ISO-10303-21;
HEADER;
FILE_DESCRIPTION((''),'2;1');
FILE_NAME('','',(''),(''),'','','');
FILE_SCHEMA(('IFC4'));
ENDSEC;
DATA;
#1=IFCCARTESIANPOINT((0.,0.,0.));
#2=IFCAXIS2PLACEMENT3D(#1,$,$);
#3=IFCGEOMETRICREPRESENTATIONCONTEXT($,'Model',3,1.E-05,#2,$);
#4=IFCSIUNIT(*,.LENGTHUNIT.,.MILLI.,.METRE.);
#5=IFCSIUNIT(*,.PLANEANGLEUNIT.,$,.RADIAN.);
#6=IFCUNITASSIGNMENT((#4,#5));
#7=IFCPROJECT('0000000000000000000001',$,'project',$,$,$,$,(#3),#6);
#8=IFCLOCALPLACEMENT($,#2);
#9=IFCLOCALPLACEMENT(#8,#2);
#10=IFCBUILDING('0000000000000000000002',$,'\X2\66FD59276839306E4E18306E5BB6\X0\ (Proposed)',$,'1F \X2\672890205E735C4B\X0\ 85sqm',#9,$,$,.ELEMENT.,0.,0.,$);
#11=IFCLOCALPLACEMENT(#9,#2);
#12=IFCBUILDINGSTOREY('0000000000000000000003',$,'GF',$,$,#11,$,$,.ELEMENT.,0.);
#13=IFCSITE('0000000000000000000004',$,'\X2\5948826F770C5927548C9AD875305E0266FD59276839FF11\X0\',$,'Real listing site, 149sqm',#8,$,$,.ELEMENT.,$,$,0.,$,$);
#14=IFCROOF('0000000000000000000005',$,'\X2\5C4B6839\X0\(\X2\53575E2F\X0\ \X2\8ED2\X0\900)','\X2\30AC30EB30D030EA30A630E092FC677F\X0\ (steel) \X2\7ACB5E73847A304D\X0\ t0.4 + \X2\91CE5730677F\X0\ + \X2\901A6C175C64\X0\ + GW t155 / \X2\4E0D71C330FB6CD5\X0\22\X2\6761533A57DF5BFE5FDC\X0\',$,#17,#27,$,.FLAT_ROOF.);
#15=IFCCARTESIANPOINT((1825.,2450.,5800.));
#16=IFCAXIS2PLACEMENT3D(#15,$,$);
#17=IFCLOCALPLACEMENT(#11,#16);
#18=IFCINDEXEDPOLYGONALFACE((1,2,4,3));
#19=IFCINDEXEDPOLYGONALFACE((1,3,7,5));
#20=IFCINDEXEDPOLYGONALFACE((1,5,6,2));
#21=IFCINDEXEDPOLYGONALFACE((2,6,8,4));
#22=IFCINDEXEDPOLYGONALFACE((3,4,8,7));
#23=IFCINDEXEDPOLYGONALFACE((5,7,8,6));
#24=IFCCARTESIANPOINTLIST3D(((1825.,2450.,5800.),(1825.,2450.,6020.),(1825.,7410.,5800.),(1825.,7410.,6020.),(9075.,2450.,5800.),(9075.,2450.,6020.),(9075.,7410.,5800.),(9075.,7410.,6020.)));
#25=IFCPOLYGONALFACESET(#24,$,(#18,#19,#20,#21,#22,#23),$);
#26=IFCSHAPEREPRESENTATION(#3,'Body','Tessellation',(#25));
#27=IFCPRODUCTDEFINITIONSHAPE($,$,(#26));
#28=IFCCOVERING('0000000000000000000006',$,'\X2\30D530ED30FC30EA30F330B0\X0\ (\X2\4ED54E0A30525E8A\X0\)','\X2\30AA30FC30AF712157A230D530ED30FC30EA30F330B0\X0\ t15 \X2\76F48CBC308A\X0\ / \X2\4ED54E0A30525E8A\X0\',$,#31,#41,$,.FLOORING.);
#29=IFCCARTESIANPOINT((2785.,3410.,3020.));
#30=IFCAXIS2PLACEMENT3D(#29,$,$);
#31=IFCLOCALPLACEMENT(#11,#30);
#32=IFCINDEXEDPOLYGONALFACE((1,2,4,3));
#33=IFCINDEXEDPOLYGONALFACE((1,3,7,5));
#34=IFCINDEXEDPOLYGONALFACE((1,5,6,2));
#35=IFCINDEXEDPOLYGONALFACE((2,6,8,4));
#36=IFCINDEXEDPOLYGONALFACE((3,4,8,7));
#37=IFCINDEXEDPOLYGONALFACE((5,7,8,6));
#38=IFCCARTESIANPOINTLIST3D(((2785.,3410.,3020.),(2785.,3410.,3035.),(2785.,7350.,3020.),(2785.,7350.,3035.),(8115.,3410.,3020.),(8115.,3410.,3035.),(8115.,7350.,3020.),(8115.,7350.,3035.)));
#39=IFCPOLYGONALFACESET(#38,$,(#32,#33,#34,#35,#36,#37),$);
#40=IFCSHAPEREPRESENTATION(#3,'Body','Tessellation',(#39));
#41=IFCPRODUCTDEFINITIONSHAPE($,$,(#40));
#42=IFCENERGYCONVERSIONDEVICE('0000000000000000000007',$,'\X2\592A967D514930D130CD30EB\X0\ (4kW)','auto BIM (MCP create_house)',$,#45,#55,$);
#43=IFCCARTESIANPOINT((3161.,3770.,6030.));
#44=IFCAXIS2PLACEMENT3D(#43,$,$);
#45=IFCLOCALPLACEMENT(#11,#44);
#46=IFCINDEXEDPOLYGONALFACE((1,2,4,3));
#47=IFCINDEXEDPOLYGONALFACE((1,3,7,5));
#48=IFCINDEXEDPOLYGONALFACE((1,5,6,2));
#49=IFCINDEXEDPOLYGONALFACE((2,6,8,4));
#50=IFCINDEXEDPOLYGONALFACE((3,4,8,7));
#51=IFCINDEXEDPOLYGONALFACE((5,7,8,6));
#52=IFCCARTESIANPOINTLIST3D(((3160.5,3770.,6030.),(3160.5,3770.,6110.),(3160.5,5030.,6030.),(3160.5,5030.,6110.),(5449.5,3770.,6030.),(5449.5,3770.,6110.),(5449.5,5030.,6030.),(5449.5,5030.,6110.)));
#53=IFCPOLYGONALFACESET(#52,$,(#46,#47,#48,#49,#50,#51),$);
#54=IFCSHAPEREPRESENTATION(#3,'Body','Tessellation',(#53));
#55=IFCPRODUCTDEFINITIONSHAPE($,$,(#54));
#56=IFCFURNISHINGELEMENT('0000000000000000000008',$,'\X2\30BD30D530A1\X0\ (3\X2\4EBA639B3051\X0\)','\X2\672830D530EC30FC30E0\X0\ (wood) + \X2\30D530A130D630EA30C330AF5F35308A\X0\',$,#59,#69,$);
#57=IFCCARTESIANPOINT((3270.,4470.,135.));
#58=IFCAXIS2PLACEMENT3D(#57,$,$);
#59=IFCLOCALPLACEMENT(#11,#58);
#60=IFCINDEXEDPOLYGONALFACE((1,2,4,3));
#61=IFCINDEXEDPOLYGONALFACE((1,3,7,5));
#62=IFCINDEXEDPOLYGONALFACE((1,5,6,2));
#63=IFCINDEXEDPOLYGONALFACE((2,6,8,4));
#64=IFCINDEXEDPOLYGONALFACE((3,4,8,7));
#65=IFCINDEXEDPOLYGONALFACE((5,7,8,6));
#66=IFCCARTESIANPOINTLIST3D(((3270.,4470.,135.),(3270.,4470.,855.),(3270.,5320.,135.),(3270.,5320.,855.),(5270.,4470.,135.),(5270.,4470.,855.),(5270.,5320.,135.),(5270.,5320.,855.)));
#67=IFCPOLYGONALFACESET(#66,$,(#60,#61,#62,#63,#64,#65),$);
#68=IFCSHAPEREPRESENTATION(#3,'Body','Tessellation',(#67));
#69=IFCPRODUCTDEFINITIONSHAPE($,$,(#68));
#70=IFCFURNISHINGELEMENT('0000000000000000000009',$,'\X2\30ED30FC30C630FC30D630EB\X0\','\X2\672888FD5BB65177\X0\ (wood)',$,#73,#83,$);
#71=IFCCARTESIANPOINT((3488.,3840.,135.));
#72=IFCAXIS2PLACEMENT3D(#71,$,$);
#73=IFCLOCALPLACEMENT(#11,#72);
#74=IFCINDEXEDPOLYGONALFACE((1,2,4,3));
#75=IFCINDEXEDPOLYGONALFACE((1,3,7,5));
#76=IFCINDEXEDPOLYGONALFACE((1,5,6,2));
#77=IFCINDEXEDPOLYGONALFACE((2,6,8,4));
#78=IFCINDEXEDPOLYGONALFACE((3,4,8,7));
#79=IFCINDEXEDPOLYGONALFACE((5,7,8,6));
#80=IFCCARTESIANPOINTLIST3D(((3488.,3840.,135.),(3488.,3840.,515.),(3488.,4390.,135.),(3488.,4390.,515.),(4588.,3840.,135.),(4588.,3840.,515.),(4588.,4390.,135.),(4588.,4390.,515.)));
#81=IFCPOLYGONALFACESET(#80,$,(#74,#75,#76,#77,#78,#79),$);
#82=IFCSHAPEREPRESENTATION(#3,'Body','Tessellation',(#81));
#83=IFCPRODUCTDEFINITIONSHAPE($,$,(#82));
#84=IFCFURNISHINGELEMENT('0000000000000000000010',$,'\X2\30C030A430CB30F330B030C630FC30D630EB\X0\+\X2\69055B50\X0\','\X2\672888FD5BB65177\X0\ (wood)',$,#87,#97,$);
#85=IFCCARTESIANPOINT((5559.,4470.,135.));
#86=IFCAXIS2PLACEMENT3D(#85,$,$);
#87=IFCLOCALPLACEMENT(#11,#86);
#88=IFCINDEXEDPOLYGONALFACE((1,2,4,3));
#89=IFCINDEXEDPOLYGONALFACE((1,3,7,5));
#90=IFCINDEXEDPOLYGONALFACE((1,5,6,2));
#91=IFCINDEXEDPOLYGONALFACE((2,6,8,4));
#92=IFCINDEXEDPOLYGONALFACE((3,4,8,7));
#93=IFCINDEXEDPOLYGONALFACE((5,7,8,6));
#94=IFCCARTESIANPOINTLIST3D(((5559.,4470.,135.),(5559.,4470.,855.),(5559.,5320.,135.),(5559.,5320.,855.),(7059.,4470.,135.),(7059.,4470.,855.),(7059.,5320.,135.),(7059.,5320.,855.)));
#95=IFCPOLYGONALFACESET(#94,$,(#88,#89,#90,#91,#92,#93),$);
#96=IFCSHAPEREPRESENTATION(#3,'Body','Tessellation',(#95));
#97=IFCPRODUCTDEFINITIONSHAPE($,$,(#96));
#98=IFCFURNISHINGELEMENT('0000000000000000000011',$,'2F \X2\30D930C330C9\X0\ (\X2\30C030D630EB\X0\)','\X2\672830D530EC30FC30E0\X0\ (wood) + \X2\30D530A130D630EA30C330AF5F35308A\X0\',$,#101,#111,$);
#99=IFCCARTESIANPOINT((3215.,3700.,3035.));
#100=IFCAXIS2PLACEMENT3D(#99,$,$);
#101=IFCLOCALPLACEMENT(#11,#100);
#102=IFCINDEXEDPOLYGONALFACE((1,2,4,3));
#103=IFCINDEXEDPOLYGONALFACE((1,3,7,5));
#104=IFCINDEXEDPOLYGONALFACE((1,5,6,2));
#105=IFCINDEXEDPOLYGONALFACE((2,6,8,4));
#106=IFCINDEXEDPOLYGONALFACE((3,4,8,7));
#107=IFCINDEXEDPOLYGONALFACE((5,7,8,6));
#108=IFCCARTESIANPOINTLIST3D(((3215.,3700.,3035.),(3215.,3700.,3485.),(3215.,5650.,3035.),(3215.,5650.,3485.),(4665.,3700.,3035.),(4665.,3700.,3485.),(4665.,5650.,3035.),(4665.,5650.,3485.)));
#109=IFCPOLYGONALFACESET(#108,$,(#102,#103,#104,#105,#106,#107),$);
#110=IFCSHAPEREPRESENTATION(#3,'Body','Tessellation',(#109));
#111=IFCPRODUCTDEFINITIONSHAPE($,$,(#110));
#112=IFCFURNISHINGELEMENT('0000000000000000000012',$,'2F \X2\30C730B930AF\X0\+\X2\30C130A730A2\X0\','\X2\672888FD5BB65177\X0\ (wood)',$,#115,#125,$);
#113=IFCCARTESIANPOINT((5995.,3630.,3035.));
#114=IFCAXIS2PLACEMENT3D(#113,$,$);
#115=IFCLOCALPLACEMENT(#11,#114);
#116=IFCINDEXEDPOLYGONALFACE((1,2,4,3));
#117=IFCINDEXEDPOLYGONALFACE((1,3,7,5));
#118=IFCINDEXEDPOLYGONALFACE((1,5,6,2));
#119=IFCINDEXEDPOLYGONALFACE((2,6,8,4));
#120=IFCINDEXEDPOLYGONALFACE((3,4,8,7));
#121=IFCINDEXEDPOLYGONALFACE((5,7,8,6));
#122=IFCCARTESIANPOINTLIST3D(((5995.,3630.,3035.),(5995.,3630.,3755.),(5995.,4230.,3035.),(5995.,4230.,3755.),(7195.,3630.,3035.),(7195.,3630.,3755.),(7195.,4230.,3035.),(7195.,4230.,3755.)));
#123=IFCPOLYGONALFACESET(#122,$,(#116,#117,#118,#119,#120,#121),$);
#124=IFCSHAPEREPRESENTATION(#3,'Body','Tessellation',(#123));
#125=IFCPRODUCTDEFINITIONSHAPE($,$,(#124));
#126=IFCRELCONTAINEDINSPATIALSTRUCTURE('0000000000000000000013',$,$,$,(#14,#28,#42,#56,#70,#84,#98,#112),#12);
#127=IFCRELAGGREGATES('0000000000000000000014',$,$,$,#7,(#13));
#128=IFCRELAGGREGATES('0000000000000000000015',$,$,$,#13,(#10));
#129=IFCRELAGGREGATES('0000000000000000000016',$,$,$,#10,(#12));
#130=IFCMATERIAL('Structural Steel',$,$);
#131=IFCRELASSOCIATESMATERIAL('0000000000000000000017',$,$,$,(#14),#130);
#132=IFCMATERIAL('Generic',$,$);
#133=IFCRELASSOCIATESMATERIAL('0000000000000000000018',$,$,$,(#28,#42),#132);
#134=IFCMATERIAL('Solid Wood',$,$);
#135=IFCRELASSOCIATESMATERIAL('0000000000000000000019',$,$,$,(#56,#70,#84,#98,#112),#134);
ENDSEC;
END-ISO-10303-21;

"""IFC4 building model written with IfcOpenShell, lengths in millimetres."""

from ifc_helpers import new_model, si_unit, frame, frame_2d, origin, place, context, project, spatial, rectangle, extrude, material, element, save


model = new_model("IFC4")

# Units and contexts
model_context = context("Model", 3, precision=1e-05, world=origin())
ifc_project = project(units=[si_unit("LENGTHUNIT", "METRE", prefix="MILLI"), si_unit("PLANEANGLEUNIT", "RADIAN")], contexts=[model_context])

# Site, building, storey
site_placement = place(None, origin())
site = spatial("IfcSite", under=ifc_project, at=site_placement, Name="奈良県大和高田市曽大根１", ObjectType="Real listing site, 149sqm", CompositionType="ELEMENT", RefElevation=0.0)
building_placement = place(site_placement, origin())
building = spatial("IfcBuilding", under=site, at=building_placement, Name="曽大根の丘の家 (Proposed)", ObjectType="1F 木造平屋 85sqm", CompositionType="ELEMENT", ElevationOfRefHeight=0.0, ElevationOfTerrain=0.0)
storey_placement = place(building_placement, origin())
storey = spatial("IfcBuildingStorey", under=building, at=storey_placement, Name="GF", CompositionType="ELEMENT", Elevation=0.0)

# Shared definitions
ifc_material_1 = material(Name="Solid Wood")

# Shared definitions
ifc_material_2 = material(Name="Generic")

# Roof
ifc_material_3 = material(Name="Structural Steel")
for number, where, name in (
    (1, (1825.0, 2450.0, 5800.0), "屋根(南帯 軒900)"),
):
    element("IfcRoof", number, at=place(storey_placement, frame(where)), inside=storey, material=ifc_material_3, Name=name, Description="ガルバリウム鋼板 (steel) 立平葺き t0.4 + 野地板 + 通気層 + GW t155 / 不燃・法22条区域対応", PredefinedType="FLAT_ROOF", context=model_context, shape_type="SweptSolid", body=[
        extrude(rectangle(XDim=7250.0, YDim=4960.0, at=frame_2d((3625.0, 2480.0))), frame((1825.0, 2450.0, 5800.0)), (0.0, 0.0, 1.0), 220.0),
    ])

# Covering
covering_placement = place(storey_placement, frame((2785.0, 3410.0, 3020.0)))
element("IfcCovering", 2, at=covering_placement, inside=storey, material=ifc_material_2, Name="フローリング (仕上げ床)", Description="オーク無垢フローリング t15 直貼り / 仕上げ床", PredefinedType="FLOORING", context=model_context, shape_type="SweptSolid", body=[
    extrude(rectangle(XDim=5330.0, YDim=3940.0, at=frame_2d((2665.0, 1970.0))), frame((2785.0, 3410.0, 3020.0)), (0.0, 0.0, 1.0), 15.0),
])

# Energy conversion device
energy_conversion_device_placement = place(storey_placement, frame((3161.0, 3770.0, 6030.0)))
element("IfcEnergyConversionDevice", 3, at=energy_conversion_device_placement, inside=storey, material=ifc_material_2, Name="太陽光パネル (4kW)", Description="auto BIM (MCP create_house)", context=model_context, shape_type="SweptSolid", body=[
    extrude(rectangle(XDim=2289.0, YDim=1260.0, at=frame_2d((1144.0, 630.0))), frame((3161.0, 3770.0, 6030.0)), (0.0, 0.0, 1.0), 80.0),
])

# Furnishing elements
furnishing_1_placement = place(storey_placement, frame((3270.0, 4470.0, 135.0)))
element("IfcFurnishingElement", 4, at=furnishing_1_placement, inside=storey, material=ifc_material_1, Name="ソファ (3人掛け)", Description="木フレーム (wood) + ファブリック張り", context=model_context, shape_type="SweptSolid", body=[
    extrude(rectangle(XDim=2000.0, YDim=850.0, at=frame_2d((1000.0, 425.0))), frame((3270.0, 4470.0, 135.0)), (0.0, 0.0, 1.0), 720.0),
])
furnishing_2_placement = place(storey_placement, frame((3488.0, 3840.0, 135.0)))
element("IfcFurnishingElement", 5, at=furnishing_2_placement, inside=storey, material=ifc_material_1, Name="ローテーブル", Description="木製家具 (wood)", context=model_context, shape_type="SweptSolid", body=[
    extrude(rectangle(XDim=1100.0, YDim=550.0, at=frame_2d((550.0, 275.0))), frame((3488.0, 3840.0, 135.0)), (0.0, 0.0, 1.0), 380.0),
])
furnishing_3_placement = place(storey_placement, frame((5559.0, 4470.0, 135.0)))
element("IfcFurnishingElement", 6, at=furnishing_3_placement, inside=storey, material=ifc_material_1, Name="ダイニングテーブル+椅子", Description="木製家具 (wood)", context=model_context, shape_type="SweptSolid", body=[
    extrude(rectangle(XDim=1500.0, YDim=850.0, at=frame_2d((750.0, 425.0))), frame((5559.0, 4470.0, 135.0)), (0.0, 0.0, 1.0), 720.0),
])
furnishing_4_placement = place(storey_placement, frame((3215.0, 3700.0, 3035.0)))
element("IfcFurnishingElement", 7, at=furnishing_4_placement, inside=storey, material=ifc_material_1, Name="2F ベッド (ダブル)", Description="木フレーム (wood) + ファブリック張り", context=model_context, shape_type="SweptSolid", body=[
    extrude(rectangle(XDim=1450.0, YDim=1950.0, at=frame_2d((725.0, 975.0))), frame((3215.0, 3700.0, 3035.0)), (0.0, 0.0, 1.0), 450.0),
])
furnishing_5_placement = place(storey_placement, frame((5995.0, 3630.0, 3035.0)))
element("IfcFurnishingElement", 8, at=furnishing_5_placement, inside=storey, material=ifc_material_1, Name="2F デスク+チェア", Description="木製家具 (wood)", context=model_context, shape_type="SweptSolid", body=[
    extrude(rectangle(XDim=1200.0, YDim=600.0, at=frame_2d((600.0, 300.0))), frame((5995.0, 3630.0, 3035.0)), (0.0, 0.0, 1.0), 720.0),
])

save(model, "model.ifc")
